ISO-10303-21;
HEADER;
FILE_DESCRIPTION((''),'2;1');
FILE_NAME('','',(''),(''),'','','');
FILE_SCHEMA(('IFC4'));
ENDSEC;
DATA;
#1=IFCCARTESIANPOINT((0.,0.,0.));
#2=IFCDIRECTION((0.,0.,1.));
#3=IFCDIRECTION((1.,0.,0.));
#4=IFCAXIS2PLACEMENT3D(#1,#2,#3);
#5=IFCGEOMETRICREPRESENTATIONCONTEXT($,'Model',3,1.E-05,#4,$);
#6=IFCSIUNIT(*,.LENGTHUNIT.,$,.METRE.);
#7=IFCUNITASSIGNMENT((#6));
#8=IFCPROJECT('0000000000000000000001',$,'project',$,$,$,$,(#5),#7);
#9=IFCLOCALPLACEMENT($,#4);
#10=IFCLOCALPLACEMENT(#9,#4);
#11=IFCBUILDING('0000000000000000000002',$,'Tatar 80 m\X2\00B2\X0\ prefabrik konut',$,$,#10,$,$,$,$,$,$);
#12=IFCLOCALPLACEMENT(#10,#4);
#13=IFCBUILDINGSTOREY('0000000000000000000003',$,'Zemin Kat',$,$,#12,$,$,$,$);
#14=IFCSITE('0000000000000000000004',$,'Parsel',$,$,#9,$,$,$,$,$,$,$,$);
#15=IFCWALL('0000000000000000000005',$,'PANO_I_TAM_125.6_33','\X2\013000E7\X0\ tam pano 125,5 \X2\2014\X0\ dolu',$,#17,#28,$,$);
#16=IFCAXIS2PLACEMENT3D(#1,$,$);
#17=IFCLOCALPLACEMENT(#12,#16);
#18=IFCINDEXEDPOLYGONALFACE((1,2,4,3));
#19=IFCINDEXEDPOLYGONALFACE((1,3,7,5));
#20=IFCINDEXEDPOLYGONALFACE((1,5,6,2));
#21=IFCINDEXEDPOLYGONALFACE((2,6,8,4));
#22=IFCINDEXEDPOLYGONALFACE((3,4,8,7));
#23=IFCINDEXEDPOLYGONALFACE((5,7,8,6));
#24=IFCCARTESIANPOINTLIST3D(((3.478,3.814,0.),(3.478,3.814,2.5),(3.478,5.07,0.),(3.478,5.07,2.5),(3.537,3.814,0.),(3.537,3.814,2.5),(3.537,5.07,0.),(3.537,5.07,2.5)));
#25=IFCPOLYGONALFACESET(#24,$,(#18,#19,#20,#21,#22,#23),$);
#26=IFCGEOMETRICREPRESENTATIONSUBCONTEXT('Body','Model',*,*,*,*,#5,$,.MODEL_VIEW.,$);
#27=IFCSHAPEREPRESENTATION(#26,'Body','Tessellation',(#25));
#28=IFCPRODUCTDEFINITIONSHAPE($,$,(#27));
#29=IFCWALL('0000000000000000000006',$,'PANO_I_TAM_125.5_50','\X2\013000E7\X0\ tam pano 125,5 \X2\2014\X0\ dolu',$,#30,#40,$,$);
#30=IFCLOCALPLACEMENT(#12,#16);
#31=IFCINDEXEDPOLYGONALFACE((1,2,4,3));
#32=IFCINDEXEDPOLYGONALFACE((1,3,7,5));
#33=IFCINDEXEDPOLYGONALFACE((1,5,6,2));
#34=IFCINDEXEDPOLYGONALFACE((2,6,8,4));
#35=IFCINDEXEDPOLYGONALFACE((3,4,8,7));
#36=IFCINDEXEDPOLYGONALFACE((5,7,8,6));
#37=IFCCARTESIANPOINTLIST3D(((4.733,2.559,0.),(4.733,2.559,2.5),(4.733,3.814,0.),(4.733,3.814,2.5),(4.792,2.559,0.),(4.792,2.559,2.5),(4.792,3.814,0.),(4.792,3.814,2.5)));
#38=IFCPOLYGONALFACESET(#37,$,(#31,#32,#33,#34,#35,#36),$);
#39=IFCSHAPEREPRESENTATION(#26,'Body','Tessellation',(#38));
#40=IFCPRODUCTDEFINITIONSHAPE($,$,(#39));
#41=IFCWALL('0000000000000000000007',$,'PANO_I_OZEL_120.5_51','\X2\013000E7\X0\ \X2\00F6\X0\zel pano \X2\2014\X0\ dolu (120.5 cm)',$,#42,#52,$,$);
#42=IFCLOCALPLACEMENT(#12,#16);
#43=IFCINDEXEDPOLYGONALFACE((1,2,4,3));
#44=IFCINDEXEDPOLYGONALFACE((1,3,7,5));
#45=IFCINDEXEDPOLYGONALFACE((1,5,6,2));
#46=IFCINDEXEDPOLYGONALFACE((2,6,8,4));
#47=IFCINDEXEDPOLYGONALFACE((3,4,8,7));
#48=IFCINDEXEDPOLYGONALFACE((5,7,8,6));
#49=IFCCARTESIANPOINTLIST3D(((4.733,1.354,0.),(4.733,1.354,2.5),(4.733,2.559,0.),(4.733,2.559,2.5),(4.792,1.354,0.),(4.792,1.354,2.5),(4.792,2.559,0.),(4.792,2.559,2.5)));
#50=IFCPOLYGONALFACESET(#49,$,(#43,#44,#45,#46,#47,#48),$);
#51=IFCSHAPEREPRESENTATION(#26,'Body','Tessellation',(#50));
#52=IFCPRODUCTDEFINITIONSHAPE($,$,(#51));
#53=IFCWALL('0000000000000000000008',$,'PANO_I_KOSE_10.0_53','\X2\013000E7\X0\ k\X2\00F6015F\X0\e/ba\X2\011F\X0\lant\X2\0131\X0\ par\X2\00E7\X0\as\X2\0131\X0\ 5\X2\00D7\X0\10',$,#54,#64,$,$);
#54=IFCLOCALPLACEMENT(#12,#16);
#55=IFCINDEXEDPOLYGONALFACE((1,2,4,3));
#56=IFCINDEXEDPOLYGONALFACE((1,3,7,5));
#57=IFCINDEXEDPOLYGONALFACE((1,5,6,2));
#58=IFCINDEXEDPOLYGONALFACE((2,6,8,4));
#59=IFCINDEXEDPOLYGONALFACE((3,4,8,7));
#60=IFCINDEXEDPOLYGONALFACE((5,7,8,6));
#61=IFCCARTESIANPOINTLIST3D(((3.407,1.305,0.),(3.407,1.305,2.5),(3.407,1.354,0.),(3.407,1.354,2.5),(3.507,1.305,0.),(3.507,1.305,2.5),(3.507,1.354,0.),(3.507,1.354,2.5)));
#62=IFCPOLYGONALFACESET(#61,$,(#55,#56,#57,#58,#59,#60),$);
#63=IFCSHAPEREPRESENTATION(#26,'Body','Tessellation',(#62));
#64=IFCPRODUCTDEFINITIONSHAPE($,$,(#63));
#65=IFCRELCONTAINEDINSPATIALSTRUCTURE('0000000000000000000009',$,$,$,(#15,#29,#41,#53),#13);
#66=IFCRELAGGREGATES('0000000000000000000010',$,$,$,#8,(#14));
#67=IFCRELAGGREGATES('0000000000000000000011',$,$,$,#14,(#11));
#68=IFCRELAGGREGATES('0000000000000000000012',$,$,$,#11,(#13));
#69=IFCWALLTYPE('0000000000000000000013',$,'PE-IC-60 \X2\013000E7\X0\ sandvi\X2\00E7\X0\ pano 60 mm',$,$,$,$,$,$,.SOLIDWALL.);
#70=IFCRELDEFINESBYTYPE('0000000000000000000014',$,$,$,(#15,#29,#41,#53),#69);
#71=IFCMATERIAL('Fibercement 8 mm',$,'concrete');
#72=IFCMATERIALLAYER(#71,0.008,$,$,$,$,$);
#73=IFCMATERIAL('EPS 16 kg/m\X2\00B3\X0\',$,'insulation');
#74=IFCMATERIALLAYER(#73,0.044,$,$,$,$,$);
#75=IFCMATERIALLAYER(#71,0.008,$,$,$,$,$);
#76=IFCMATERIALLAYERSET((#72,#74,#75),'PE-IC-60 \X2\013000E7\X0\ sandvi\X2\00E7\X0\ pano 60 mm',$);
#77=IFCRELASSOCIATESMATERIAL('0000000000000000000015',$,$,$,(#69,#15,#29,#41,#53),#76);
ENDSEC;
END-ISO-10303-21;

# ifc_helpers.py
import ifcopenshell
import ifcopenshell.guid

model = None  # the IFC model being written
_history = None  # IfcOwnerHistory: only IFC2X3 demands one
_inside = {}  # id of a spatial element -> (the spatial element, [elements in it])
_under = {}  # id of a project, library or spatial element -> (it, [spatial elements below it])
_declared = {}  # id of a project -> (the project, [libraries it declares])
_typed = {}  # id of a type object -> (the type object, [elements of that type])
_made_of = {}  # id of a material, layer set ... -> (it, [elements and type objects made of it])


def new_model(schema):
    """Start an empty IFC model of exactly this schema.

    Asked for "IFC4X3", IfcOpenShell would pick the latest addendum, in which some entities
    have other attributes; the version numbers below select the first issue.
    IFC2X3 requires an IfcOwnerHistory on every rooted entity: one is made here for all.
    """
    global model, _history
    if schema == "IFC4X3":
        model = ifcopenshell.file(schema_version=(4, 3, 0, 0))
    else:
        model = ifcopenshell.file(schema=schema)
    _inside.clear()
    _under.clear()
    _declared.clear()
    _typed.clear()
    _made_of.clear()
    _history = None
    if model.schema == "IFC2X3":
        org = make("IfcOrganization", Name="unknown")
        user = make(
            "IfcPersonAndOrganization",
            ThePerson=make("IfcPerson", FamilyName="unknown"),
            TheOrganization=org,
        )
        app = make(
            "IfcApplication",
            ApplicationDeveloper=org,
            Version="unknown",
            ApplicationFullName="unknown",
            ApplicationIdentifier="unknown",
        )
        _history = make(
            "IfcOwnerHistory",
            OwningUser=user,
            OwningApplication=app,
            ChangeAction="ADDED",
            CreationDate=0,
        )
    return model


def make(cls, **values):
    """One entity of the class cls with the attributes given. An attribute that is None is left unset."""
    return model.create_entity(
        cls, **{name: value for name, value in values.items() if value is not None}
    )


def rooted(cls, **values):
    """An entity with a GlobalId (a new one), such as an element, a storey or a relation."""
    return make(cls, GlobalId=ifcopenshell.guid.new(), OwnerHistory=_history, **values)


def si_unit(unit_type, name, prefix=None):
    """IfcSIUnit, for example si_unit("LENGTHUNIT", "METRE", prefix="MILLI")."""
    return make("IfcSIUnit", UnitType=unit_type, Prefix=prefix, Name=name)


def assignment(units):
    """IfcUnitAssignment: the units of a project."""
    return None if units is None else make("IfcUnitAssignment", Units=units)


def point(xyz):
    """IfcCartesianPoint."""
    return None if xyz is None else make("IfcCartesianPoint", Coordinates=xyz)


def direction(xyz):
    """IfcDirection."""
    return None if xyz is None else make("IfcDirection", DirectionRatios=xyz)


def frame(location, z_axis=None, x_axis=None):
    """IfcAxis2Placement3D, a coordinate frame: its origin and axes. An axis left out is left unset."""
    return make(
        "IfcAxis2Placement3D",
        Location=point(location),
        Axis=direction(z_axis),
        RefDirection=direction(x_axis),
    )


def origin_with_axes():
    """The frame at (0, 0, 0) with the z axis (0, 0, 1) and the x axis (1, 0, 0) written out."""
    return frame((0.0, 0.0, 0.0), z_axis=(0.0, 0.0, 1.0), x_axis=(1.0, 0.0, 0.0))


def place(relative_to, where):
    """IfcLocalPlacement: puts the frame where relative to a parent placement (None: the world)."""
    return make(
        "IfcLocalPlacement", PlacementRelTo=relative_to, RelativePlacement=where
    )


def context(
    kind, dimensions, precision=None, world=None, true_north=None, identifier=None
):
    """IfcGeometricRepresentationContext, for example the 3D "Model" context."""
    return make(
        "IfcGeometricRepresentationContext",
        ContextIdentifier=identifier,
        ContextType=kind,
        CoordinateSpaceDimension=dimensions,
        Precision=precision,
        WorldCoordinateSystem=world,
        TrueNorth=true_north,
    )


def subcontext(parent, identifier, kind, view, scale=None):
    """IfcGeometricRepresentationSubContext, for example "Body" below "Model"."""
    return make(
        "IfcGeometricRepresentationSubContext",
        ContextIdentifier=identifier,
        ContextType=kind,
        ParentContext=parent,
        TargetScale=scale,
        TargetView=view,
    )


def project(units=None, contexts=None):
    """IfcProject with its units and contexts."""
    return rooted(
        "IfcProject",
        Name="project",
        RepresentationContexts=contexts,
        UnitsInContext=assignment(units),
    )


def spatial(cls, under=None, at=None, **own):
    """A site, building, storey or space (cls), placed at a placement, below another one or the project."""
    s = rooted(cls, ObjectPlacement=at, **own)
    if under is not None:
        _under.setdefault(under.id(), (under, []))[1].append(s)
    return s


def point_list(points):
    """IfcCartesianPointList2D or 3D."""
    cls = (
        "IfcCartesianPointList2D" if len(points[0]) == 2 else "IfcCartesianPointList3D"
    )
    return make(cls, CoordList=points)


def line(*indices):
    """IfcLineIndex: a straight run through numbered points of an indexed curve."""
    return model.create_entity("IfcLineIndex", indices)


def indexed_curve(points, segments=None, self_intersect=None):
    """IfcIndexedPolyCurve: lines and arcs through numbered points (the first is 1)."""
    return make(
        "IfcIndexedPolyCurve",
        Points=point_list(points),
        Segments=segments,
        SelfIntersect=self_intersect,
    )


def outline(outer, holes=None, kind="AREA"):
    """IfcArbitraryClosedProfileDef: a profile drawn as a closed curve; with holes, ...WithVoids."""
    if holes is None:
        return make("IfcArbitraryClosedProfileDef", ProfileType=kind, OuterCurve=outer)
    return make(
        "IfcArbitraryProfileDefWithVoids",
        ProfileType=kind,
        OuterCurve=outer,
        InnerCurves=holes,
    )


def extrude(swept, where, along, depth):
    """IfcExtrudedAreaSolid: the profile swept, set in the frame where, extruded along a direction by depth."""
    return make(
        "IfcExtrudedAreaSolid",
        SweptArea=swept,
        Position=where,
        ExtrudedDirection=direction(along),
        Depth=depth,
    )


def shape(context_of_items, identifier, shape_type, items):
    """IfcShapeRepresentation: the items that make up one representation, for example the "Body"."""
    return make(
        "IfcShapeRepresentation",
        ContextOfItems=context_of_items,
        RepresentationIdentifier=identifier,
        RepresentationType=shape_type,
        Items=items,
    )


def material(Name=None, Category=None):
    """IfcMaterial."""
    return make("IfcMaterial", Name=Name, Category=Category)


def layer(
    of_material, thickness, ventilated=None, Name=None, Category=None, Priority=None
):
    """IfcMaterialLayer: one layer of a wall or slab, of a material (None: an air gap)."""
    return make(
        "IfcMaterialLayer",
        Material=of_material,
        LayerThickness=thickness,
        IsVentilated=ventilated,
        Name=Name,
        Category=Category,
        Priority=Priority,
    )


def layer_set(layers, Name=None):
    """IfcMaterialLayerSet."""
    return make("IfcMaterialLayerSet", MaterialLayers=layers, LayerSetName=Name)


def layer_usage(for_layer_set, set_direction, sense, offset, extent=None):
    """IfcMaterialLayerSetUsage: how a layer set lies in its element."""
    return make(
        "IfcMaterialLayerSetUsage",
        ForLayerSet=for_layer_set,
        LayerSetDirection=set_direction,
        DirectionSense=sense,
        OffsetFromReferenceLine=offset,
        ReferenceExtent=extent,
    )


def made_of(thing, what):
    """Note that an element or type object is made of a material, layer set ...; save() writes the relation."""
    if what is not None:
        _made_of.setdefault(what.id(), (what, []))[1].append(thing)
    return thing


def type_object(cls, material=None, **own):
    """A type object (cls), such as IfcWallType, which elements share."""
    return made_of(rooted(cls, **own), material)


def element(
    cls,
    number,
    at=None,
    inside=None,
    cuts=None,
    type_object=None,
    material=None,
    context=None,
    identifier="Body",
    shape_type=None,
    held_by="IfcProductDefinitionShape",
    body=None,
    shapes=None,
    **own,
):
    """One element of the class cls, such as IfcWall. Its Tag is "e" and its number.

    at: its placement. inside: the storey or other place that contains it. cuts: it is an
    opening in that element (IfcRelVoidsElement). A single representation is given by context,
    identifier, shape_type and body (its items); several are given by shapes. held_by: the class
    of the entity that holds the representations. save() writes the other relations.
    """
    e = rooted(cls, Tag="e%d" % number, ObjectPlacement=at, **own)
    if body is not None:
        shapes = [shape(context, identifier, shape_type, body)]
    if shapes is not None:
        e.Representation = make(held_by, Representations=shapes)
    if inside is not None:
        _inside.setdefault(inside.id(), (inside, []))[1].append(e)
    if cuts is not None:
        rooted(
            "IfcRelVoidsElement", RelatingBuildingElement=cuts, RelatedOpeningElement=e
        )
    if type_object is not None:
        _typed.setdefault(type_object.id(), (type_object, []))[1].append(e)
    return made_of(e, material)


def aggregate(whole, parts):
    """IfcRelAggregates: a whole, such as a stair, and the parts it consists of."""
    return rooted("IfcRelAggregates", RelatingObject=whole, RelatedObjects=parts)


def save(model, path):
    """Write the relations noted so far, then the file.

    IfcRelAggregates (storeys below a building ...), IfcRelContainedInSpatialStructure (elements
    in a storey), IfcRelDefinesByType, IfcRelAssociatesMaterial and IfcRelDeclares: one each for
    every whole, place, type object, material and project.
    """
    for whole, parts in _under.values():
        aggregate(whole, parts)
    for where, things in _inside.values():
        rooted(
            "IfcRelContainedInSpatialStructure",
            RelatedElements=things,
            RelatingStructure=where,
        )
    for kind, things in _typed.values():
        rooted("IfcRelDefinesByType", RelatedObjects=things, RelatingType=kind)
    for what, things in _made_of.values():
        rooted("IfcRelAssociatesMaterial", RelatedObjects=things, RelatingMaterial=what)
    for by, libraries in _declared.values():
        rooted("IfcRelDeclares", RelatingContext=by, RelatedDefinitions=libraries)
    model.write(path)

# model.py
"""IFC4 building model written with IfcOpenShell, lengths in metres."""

from ifc_helpers import new_model, si_unit, frame, origin_with_axes, place, context, subcontext, project, spatial, line, indexed_curve, outline, extrude, material, layer, layer_set, layer_usage, type_object, element, save


model = new_model("IFC4")

# Units and contexts
model_context = context("Model", 3, precision=1e-05, world=origin_with_axes())
body_context = subcontext(model_context, "Body", "Model", "MODEL_VIEW")
ifc_project = project(units=[si_unit("LENGTHUNIT", "METRE")], contexts=[model_context])

# Site, building, storey
site_placement = place(None, origin_with_axes())
site = spatial("IfcSite", under=ifc_project, at=site_placement, Name="Parsel")
building_placement = place(site_placement, origin_with_axes())
building = spatial("IfcBuilding", under=site, at=building_placement, Name="Tatar 80 m² prefabrik konut")
storey_placement = place(building_placement, origin_with_axes())
storey = spatial("IfcBuildingStorey", under=building, at=storey_placement, Name="Zemin Kat")

# Shared definitions
ifc_material_1 = material(Name="Fibercement 8 mm", Category="concrete")
ifc_material_2 = material(Name="EPS 16 kg/m³", Category="insulation")

# Shared definitions
ifc_layer_1 = layer(ifc_material_1, 0.008)
ifc_layer_2 = layer(ifc_material_2, 0.044)
ifc_layer_3 = layer(ifc_material_1, 0.008)
ifc_layer_set_1 = layer_set([ifc_layer_1, ifc_layer_2, ifc_layer_3], Name="PE-IC-60 İç sandviç pano 60 mm")
wall_type_1 = type_object("IfcWallType", Name="PE-IC-60 İç sandviç pano 60 mm", PredefinedType="SOLIDWALL", material=ifc_layer_set_1)

# Walls
ifc_layer_usage_1 = layer_usage(ifc_layer_set_1, "AXIS2", "POSITIVE", 0.0)
wall_1_placement = place(storey_placement, frame((3.537, 3.814, 0.0), z_axis=(0.0, 0.0, 1.0), x_axis=(0.0, 1.0, 0.0)))
element("IfcWall", 1, at=wall_1_placement, inside=storey, type_object=wall_type_1, material=ifc_layer_usage_1, Name="PANO_I_TAM_125.6_33", Description="İç tam pano 125,5 — dolu", context=body_context, shape_type="SweptSolid", body=[
    extrude(outline(indexed_curve([(0.0, 0.0), (1.256, 0.0), (1.256, 0.059), (0.0, 0.059)], segments=[line(1, 2, 3, 4, 1)])), origin_with_axes(), (0.0, 0.0, 1.0), 2.5),
])
ifc_layer_usage_2 = layer_usage(ifc_layer_set_1, "AXIS2", "POSITIVE", 0.0)
wall_2_placement = place(storey_placement, frame((4.792, 2.559, 0.0), z_axis=(0.0, 0.0, 1.0), x_axis=(0.0, 1.0, 0.0)))
element("IfcWall", 2, at=wall_2_placement, inside=storey, type_object=wall_type_1, material=ifc_layer_usage_2, Name="PANO_I_TAM_125.5_50", Description="İç tam pano 125,5 — dolu", context=body_context, shape_type="SweptSolid", body=[
    extrude(outline(indexed_curve([(0.0, 0.0), (1.255, 0.0), (1.255, 0.059), (0.0, 0.059)], segments=[line(1, 2, 3, 4, 1)])), origin_with_axes(), (0.0, 0.0, 1.0), 2.5),
])
ifc_layer_usage_3 = layer_usage(ifc_layer_set_1, "AXIS2", "POSITIVE", 0.0)
wall_3_placement = place(storey_placement, frame((4.792, 1.354, 0.0), z_axis=(0.0, 0.0, 1.0), x_axis=(0.0, 1.0, 0.0)))
element("IfcWall", 3, at=wall_3_placement, inside=storey, type_object=wall_type_1, material=ifc_layer_usage_3, Name="PANO_I_OZEL_120.5_51", Description="İç özel pano — dolu (120.5 cm)", context=body_context, shape_type="SweptSolid", body=[
    extrude(outline(indexed_curve([(0.0, 0.0), (1.205, 0.0), (1.205, 0.059), (0.0, 0.059)], segments=[line(1, 2, 3, 4, 1)])), origin_with_axes(), (0.0, 0.0, 1.0), 2.5),
])
ifc_layer_usage_4 = layer_usage(ifc_layer_set_1, "AXIS2", "POSITIVE", 0.0)
wall_4_placement = place(storey_placement, frame((3.407, 1.305, 0.0), z_axis=(0.0, 0.0, 1.0), x_axis=(1.0, 0.0, 0.0)))
element("IfcWall", 4, at=wall_4_placement, inside=storey, type_object=wall_type_1, material=ifc_layer_usage_4, Name="PANO_I_KOSE_10.0_53", Description="İç köşe/bağlantı parçası 5×10", context=body_context, shape_type="SweptSolid", body=[
    extrude(outline(indexed_curve([(0.0, 0.0), (0.1, 0.0), (0.1, 0.049), (0.0, 0.049)], segments=[line(1, 2, 3, 4, 1)])), origin_with_axes(), (0.0, 0.0, 1.0), 2.5),
])

save(model, "model.ifc")
